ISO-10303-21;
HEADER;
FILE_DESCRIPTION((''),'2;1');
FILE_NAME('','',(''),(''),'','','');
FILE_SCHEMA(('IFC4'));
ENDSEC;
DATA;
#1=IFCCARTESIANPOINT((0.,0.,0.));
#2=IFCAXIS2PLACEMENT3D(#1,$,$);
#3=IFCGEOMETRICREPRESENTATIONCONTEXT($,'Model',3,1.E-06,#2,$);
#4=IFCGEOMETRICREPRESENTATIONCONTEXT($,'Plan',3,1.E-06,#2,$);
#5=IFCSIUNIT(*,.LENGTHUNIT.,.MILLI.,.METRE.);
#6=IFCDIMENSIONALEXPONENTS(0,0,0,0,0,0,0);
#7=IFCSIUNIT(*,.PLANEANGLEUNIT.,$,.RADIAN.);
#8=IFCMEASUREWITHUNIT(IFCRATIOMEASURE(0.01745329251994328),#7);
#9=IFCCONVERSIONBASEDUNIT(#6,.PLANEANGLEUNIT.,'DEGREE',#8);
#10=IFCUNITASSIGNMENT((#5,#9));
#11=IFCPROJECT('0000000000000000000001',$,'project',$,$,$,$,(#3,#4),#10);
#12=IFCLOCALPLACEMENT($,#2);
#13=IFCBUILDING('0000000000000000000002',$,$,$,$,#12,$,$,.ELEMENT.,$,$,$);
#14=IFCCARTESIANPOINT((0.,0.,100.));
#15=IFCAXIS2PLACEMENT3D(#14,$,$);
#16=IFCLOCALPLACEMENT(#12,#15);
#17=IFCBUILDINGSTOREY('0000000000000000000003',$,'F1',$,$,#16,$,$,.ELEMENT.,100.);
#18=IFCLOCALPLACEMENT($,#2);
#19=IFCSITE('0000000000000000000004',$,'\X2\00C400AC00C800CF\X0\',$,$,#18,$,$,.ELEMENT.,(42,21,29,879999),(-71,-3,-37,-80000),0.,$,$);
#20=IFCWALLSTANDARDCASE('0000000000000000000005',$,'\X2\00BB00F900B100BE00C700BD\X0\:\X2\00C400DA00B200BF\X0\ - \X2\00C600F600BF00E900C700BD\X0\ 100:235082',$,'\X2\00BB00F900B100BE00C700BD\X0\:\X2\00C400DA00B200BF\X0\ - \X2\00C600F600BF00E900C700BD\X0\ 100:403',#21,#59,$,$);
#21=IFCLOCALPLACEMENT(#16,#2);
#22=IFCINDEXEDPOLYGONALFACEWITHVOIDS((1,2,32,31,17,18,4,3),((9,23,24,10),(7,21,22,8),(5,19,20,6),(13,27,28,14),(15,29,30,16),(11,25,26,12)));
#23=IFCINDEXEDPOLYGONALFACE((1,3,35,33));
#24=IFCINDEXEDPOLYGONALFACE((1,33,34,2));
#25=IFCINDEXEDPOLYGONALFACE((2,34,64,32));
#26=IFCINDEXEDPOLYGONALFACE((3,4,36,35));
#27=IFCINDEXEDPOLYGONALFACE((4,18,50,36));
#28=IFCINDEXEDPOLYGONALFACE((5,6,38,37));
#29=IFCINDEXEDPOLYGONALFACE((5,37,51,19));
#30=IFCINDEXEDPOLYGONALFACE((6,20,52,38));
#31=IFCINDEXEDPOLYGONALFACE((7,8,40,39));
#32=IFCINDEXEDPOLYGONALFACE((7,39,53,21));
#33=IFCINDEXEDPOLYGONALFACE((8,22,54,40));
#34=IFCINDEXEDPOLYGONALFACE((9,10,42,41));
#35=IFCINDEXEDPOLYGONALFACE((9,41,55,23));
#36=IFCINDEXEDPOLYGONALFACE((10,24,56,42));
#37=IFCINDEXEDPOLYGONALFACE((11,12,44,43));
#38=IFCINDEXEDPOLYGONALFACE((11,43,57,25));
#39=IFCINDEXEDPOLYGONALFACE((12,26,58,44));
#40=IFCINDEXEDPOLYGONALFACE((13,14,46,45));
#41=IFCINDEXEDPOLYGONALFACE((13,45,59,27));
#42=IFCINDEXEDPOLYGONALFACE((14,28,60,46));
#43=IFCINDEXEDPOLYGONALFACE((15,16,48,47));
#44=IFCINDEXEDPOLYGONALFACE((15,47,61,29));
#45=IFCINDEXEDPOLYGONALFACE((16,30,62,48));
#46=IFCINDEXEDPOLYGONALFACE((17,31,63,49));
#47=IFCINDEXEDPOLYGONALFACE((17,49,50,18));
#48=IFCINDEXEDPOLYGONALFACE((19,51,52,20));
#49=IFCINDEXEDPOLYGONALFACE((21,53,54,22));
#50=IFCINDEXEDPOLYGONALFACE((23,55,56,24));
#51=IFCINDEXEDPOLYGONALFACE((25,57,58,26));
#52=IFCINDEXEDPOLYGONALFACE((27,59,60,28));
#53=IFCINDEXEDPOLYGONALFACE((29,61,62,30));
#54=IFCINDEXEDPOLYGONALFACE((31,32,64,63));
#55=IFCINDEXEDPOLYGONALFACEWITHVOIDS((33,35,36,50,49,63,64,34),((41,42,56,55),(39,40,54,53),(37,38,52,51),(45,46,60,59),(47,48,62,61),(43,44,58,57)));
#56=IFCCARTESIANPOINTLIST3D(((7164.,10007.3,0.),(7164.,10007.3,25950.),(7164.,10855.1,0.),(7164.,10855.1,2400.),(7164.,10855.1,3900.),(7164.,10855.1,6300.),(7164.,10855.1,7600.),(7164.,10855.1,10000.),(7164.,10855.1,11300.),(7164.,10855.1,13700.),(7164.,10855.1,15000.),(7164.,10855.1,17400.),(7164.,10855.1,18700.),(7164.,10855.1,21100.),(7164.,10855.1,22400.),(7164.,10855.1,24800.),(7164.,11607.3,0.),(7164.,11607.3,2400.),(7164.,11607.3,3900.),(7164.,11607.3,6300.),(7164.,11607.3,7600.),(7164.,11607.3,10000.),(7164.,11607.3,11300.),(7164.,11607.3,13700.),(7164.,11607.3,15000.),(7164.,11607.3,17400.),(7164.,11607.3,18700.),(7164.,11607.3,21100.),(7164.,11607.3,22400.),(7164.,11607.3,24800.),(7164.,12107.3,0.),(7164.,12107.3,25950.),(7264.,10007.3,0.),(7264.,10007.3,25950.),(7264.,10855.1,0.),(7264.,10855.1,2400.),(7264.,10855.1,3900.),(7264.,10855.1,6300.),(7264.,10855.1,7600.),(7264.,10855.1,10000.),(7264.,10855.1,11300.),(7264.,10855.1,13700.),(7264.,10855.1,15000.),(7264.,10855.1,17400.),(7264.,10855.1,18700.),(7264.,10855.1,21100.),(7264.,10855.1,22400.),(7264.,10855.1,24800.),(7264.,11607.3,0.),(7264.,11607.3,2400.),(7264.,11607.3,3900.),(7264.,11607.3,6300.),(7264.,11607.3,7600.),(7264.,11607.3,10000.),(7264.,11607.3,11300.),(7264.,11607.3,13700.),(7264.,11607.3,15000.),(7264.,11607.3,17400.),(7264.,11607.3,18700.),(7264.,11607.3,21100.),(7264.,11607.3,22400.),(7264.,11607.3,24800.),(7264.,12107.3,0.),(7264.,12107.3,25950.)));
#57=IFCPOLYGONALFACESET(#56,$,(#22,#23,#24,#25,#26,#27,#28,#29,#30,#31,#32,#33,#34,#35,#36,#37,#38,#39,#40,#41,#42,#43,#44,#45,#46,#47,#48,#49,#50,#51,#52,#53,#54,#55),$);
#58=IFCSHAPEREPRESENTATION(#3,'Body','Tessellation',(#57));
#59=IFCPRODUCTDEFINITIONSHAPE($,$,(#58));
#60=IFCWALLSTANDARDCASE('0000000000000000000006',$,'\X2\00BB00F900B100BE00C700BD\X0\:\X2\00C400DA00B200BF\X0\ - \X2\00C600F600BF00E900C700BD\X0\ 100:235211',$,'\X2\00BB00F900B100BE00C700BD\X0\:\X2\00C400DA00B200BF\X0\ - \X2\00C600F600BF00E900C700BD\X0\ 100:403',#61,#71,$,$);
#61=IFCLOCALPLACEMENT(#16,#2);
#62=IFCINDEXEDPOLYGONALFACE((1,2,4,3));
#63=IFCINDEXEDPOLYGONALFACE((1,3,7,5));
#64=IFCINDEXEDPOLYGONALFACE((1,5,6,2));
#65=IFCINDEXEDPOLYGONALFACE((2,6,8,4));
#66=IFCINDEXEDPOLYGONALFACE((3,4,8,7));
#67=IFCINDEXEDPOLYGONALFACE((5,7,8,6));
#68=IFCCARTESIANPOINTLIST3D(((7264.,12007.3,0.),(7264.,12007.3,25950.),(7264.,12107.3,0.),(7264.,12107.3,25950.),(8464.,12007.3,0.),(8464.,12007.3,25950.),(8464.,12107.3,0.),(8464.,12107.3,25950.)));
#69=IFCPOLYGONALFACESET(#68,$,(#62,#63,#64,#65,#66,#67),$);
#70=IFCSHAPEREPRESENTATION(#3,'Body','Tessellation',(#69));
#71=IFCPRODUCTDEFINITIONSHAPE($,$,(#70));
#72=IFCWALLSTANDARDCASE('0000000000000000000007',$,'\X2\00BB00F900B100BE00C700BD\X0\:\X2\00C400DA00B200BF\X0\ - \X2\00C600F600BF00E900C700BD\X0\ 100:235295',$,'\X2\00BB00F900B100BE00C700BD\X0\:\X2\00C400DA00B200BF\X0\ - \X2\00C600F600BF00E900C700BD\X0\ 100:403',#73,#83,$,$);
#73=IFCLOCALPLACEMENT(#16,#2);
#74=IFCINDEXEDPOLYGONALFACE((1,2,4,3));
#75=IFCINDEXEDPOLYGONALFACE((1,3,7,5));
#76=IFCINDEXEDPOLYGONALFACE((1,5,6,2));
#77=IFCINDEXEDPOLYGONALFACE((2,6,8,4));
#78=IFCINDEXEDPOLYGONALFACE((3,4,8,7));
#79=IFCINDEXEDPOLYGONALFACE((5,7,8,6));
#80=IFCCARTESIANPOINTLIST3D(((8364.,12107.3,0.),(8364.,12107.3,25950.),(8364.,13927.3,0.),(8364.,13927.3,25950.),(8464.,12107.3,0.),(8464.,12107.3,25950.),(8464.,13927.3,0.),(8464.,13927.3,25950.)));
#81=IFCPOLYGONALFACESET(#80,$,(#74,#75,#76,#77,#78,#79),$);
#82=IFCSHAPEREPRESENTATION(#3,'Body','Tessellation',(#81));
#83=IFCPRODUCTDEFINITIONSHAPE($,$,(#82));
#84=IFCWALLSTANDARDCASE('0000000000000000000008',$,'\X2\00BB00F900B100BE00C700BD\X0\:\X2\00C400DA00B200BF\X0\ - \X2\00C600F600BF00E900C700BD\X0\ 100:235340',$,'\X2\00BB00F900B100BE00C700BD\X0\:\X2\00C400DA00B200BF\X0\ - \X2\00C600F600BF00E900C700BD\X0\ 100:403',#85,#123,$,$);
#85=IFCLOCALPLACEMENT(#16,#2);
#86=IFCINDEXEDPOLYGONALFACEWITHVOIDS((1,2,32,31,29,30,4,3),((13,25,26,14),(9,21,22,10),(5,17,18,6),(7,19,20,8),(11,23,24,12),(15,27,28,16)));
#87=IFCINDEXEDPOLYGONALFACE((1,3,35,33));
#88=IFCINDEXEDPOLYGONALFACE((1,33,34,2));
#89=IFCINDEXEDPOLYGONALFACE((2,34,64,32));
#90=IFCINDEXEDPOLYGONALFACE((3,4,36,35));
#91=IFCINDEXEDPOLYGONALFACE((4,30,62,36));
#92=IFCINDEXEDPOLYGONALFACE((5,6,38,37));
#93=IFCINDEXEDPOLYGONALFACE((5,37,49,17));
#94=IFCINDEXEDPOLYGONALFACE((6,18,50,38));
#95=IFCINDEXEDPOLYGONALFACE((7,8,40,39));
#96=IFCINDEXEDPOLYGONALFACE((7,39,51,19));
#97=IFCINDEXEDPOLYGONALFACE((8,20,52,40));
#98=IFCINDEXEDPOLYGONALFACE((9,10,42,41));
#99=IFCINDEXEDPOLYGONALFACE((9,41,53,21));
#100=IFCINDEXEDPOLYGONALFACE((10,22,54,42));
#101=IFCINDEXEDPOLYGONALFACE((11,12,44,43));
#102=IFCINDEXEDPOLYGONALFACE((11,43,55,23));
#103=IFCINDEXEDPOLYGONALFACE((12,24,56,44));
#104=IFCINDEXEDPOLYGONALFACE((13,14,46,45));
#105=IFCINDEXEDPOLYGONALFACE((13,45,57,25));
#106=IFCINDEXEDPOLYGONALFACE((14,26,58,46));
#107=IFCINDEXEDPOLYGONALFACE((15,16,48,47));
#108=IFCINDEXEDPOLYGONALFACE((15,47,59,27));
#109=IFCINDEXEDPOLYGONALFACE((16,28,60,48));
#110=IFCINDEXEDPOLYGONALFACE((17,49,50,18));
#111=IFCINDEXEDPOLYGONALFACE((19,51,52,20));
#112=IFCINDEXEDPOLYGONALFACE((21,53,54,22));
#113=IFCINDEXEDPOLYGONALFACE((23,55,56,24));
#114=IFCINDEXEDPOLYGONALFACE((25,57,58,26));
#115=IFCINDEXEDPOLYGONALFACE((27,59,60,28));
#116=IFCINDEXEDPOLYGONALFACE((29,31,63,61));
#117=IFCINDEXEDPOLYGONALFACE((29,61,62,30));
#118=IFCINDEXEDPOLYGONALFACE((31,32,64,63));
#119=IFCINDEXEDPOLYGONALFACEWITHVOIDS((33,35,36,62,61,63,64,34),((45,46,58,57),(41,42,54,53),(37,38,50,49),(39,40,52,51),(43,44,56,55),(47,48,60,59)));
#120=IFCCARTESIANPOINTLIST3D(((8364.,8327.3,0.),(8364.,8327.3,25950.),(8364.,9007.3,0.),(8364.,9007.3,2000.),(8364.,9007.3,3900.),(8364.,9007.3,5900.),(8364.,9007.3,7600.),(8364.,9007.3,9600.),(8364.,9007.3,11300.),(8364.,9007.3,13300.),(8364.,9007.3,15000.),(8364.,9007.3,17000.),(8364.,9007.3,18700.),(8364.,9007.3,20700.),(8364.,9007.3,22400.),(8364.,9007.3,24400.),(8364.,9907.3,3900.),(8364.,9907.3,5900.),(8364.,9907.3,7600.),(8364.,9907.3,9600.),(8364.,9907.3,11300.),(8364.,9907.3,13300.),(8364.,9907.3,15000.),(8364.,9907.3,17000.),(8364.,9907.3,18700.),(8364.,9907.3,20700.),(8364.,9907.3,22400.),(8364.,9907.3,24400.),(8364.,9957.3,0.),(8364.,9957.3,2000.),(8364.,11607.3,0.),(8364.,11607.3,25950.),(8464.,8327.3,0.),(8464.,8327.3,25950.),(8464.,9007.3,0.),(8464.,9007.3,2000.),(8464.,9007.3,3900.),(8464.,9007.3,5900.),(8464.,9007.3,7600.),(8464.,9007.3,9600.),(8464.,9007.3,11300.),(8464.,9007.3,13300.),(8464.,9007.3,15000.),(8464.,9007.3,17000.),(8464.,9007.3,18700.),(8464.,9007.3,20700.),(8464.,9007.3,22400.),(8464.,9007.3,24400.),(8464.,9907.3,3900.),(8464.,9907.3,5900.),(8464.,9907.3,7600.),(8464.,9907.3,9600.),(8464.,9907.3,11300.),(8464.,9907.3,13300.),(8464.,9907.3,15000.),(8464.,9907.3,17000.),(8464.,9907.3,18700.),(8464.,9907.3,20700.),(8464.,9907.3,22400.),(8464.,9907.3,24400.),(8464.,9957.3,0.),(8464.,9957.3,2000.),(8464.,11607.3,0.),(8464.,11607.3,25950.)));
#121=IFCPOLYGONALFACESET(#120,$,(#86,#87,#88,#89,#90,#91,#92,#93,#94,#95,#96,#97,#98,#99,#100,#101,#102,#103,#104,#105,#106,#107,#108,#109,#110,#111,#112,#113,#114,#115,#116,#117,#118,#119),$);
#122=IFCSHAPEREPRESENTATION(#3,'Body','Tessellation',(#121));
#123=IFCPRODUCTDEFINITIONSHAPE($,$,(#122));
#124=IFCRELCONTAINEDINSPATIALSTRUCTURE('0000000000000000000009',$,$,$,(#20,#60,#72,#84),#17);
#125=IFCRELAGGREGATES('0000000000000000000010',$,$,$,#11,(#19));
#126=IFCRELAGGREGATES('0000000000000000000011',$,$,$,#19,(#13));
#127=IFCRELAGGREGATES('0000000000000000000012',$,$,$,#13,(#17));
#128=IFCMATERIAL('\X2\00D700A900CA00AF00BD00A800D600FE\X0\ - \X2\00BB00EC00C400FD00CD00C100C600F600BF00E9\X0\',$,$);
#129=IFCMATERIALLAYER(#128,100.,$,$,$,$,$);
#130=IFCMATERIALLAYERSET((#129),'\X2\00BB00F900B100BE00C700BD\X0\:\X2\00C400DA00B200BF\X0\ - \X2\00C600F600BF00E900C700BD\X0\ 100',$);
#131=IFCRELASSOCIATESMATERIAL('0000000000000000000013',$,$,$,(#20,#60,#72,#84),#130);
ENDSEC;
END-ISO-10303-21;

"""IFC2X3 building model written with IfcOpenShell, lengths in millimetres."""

from ifc_helpers import new_model, entity, si_unit, converted_unit, frame, frame_2d, origin, origin_2d_with_axis, place, context, project, spatial, polyline, rectangle, extrude, clip, bounded_halfspace, material, layer, layer_set, layer_usage, element, save


model = new_model("IFC2X3")

# Units and contexts
model_context = context("Model", 3, precision=1e-06, world=origin())
plan_context = context("Plan", 3, precision=1e-06, world=origin())
ifc_project = project(units=[si_unit("LENGTHUNIT", "METRE", prefix="MILLI"), converted_unit("PLANEANGLEUNIT", "DEGREE", entity("IfcRatioMeasure", 0.01745329251994328), si_unit("PLANEANGLEUNIT", "RADIAN"), dimensions=[0, 0, 0, 0, 0, 0, 0])], contexts=[model_context, plan_context])

# Site, building, storey
site_placement = place(None, origin())
site = spatial("IfcSite", under=ifc_project, at=site_placement, Name="Ä¬ÈÏ", CompositionType="ELEMENT", RefLatitude=(42, 21, 29, 879999), RefLongitude=(-71, -3, -37, -80000), RefElevation=0.0)
building_placement = place(None, origin())
building = spatial("IfcBuilding", under=site, at=building_placement, CompositionType="ELEMENT")
storey_placement = place(building_placement, frame((0.0, 0.0, 100.0)))
storey = spatial("IfcBuildingStorey", under=building, at=storey_placement, Name="F1", CompositionType="ELEMENT", Elevation=100.0)

# Shared definitions
ifc_material_1 = material(Name="×©Ê¯½¨Öþ - »ìÄýÍÁÆö¿é")
ifc_layer_1 = layer(ifc_material_1, 100.0)
ifc_layer_set_1 = layer_set([ifc_layer_1], Name="»ù±¾Ç½:ÄÚ²¿ - Æö¿éÇ½ 100")

# Wall, openings
ifc_layer_usage_1 = layer_usage(ifc_layer_set_1, "AXIS2", "NEGATIVE", 50.0)
wall_1_placement = place(storey_placement, frame((7214.0, 12107.3, 0.0), z_axis=(0.0, 0.0, 1.0), x_axis=(0.0, -1.0, 0.0)))
wall_1 = element("IfcWallStandardCase", 1, at=wall_1_placement, inside=storey, material=ifc_layer_usage_1, Name="»ù±¾Ç½:ÄÚ²¿ - Æö¿éÇ½ 100:235082", ObjectType="»ù±¾Ç½:ÄÚ²¿ - Æö¿éÇ½ 100:403", context=model_context, shape_type="Clipping", body=[
    clip(extrude(rectangle(XDim=2100.0, YDim=100.0, at=frame_2d((1050.0, 0.0), x_axis=(-1.0, 0.0))), origin(), (0.0, 0.0, 1.0), 25950.0), bounded_halfspace(frame((0.0, -50.0, 25950.0), z_axis=(0.0, 0.0, -1.0), x_axis=(0.0, 1.0, 0.0)), True, frame((0.0, -50.0, 25950.0)), polyline([(0.0, 0.0), (2100.0, 0.0), (2100.0, 100.0), (500.0, 100.0), (400.0, 100.0), (100.0, 100.0), (0.0, 100.0), (0.0, 0.0)]))),
])
opening_1_placement = place(wall_1_placement, origin())
element("IfcOpeningElement", 2, at=opening_1_placement, cuts=wall_1, ObjectType="Opening", context=model_context, shape_type="SweptSolid", body=[
    extrude(rectangle(XDim=2400.0, YDim=752.2, at=origin_2d_with_axis()), frame((876.1, -50.0, 1200.0), z_axis=(0.0, 1.0, 0.0), x_axis=(0.0, 0.0, -1.0)), (0.0, 0.0, 1.0), 100.0),
])
opening_2_placement = place(wall_1_placement, origin())
element("IfcOpeningElement", 3, at=opening_2_placement, cuts=wall_1, ObjectType="Opening", context=model_context, shape_type="SweptSolid", body=[
    extrude(rectangle(XDim=2400.0, YDim=752.2, at=origin_2d_with_axis()), frame((876.1, -50.0, 5100.0), z_axis=(0.0, 1.0, 0.0), x_axis=(0.0, 0.0, -1.0)), (0.0, 0.0, 1.0), 100.0),
])
opening_3_placement = place(wall_1_placement, origin())
element("IfcOpeningElement", 4, at=opening_3_placement, cuts=wall_1, ObjectType="Opening", context=model_context, shape_type="SweptSolid", body=[
    extrude(rectangle(XDim=2400.0, YDim=752.2, at=origin_2d_with_axis()), frame((876.1, -50.0, 8800.0), z_axis=(0.0, 1.0, 0.0), x_axis=(0.0, 0.0, -1.0)), (0.0, 0.0, 1.0), 100.0),
])
opening_4_placement = place(wall_1_placement, origin())
element("IfcOpeningElement", 5, at=opening_4_placement, cuts=wall_1, ObjectType="Opening", context=model_context, shape_type="SweptSolid", body=[
    extrude(rectangle(XDim=2400.0, YDim=752.2, at=origin_2d_with_axis()), frame((876.1, -50.0, 12500.0), z_axis=(0.0, 1.0, 0.0), x_axis=(0.0, 0.0, -1.0)), (0.0, 0.0, 1.0), 100.0),
])
opening_5_placement = place(wall_1_placement, origin())
element("IfcOpeningElement", 6, at=opening_5_placement, cuts=wall_1, ObjectType="Opening", context=model_context, shape_type="SweptSolid", body=[
    extrude(rectangle(XDim=2400.0, YDim=752.2, at=origin_2d_with_axis()), frame((876.1, -50.0, 16200.0), z_axis=(0.0, 1.0, 0.0), x_axis=(0.0, 0.0, -1.0)), (0.0, 0.0, 1.0), 100.0),
])
opening_6_placement = place(wall_1_placement, origin())
element("IfcOpeningElement", 7, at=opening_6_placement, cuts=wall_1, ObjectType="Opening", context=model_context, shape_type="SweptSolid", body=[
    extrude(rectangle(XDim=2400.0, YDim=752.2, at=origin_2d_with_axis()), frame((876.1, -50.0, 19900.0), z_axis=(0.0, 1.0, 0.0), x_axis=(0.0, 0.0, -1.0)), (0.0, 0.0, 1.0), 100.0),
])
opening_7_placement = place(wall_1_placement, origin())
element("IfcOpeningElement", 8, at=opening_7_placement, cuts=wall_1, ObjectType="Opening", context=model_context, shape_type="SweptSolid", body=[
    extrude(rectangle(XDim=2400.0, YDim=752.2, at=origin_2d_with_axis()), frame((876.1, -50.0, 23600.0), z_axis=(0.0, 1.0, 0.0), x_axis=(0.0, 0.0, -1.0)), (0.0, 0.0, 1.0), 100.0),
])

# Walls
ifc_layer_usage_2 = layer_usage(ifc_layer_set_1, "AXIS2", "NEGATIVE", 50.0)
wall_2_placement = place(storey_placement, frame((7264.0, 12057.3, 0.0)))
element("IfcWallStandardCase", 9, at=wall_2_placement, inside=storey, material=ifc_layer_usage_2, Name="»ù±¾Ç½:ÄÚ²¿ - Æö¿éÇ½ 100:235211", ObjectType="»ù±¾Ç½:ÄÚ²¿ - Æö¿éÇ½ 100:403", context=model_context, shape_type="Clipping", body=[
    clip(extrude(rectangle(XDim=1200.0, YDim=100.0, at=frame_2d((600.0, 0.0), x_axis=(-1.0, 0.0))), origin(), (0.0, 0.0, 1.0), 25950.0), bounded_halfspace(frame((0.0, -50.0, 25950.0), z_axis=(0.0, 0.0, -1.0), x_axis=(1.0, 0.0, 0.0)), True, frame((0.0, -50.0, 25950.0)), polyline([(0.0, 0.0), (1200.0, 0.0), (1200.0, 100.0), (1100.0, 100.0), (0.0, 100.0), (0.0, 0.0)]))),
])
ifc_layer_usage_3 = layer_usage(ifc_layer_set_1, "AXIS2", "NEGATIVE", 50.0)
wall_3_placement = place(storey_placement, frame((8414.0, 13927.3, 0.0), z_axis=(0.0, 0.0, 1.0), x_axis=(0.0, -1.0, 0.0)))
element("IfcWallStandardCase", 10, at=wall_3_placement, inside=storey, material=ifc_layer_usage_3, Name="»ù±¾Ç½:ÄÚ²¿ - Æö¿éÇ½ 100:235295", ObjectType="»ù±¾Ç½:ÄÚ²¿ - Æö¿éÇ½ 100:403", context=model_context, shape_type="Clipping", body=[
    clip(extrude(rectangle(XDim=1820.0, YDim=100.0, at=frame_2d((910.0, 0.0), x_axis=(-1.0, 0.0))), origin(), (0.0, 0.0, 1.0), 25950.0), bounded_halfspace(frame((0.0, -50.0, 25950.0), z_axis=(0.0, 0.0, -1.0), x_axis=(0.0, 1.0, 0.0)), True, frame((0.0, -50.0, 25950.0)), polyline([(0.0, 0.0), (1820.0, 0.0), (1820.0, 100.0), (0.0, 100.0), (0.0, 0.0)]))),
])

# Wall, openings
ifc_layer_usage_4 = layer_usage(ifc_layer_set_1, "AXIS2", "NEGATIVE", 50.0)
wall_4_placement = place(storey_placement, frame((8414.0, 11607.3, 0.0), z_axis=(0.0, 0.0, 1.0), x_axis=(0.0, -1.0, 0.0)))
wall_4 = element("IfcWallStandardCase", 11, at=wall_4_placement, inside=storey, material=ifc_layer_usage_4, Name="»ù±¾Ç½:ÄÚ²¿ - Æö¿éÇ½ 100:235340", ObjectType="»ù±¾Ç½:ÄÚ²¿ - Æö¿éÇ½ 100:403", context=model_context, shape_type="Clipping", body=[
    clip(extrude(rectangle(XDim=3280.0, YDim=100.0, at=frame_2d((1640.0, 0.0), x_axis=(-1.0, 0.0))), origin(), (0.0, 0.0, 1.0), 25950.0), bounded_halfspace(frame((0.0, -50.0, 25950.0), z_axis=(0.0, 0.0, -1.0), x_axis=(0.0, 1.0, 0.0)), True, frame((0.0, -50.0, 25950.0)), polyline([(0.0, 0.0), (1600.0, 0.0), (1700.0, 0.0), (3180.0, 0.0), (3280.0, 0.0), (3280.0, 100.0), (2880.0, 100.0), (0.0, 100.0), (0.0, 0.0)]))),
])
opening_8_placement = place(wall_4_placement, origin())
element("IfcOpeningElement", 12, at=opening_8_placement, cuts=wall_4, ObjectType="Opening", context=model_context, shape_type="SweptSolid", body=[
    extrude(rectangle(XDim=2000.0, YDim=950.0, at=origin_2d_with_axis()), frame((2125.0, -50.0, 1000.0), z_axis=(0.0, 1.0, 0.0), x_axis=(0.0, 0.0, -1.0)), (0.0, 0.0, 1.0), 100.0),
])
opening_9_placement = place(wall_4_placement, origin())
element("IfcOpeningElement", 13, at=opening_9_placement, cuts=wall_4, ObjectType="Opening", context=model_context, shape_type="SweptSolid", body=[
    extrude(rectangle(XDim=2000.0, YDim=900.0, at=origin_2d_with_axis()), frame((2150.0, -50.0, 4900.0), z_axis=(0.0, 1.0, 0.0), x_axis=(0.0, 0.0, -1.0)), (0.0, 0.0, 1.0), 100.0),
])
opening_10_placement = place(wall_4_placement, origin())
element("IfcOpeningElement", 14, at=opening_10_placement, cuts=wall_4, ObjectType="Opening", context=model_context, shape_type="SweptSolid", body=[
    extrude(rectangle(XDim=2000.0, YDim=900.0, at=origin_2d_with_axis()), frame((2150.0, -50.0, 8600.0), z_axis=(0.0, 1.0, 0.0), x_axis=(0.0, 0.0, -1.0)), (0.0, 0.0, 1.0), 100.0),
])
opening_11_placement = place(wall_4_placement, origin())
element("IfcOpeningElement", 15, at=opening_11_placement, cuts=wall_4, ObjectType="Opening", context=model_context, shape_type="SweptSolid", body=[
    extrude(rectangle(XDim=2000.0, YDim=900.0, at=origin_2d_with_axis()), frame((2150.0, -50.0, 12300.0), z_axis=(0.0, 1.0, 0.0), x_axis=(0.0, 0.0, -1.0)), (0.0, 0.0, 1.0), 100.0),
])
opening_12_placement = place(wall_4_placement, origin())
element("IfcOpeningElement", 16, at=opening_12_placement, cuts=wall_4, ObjectType="Opening", context=model_context, shape_type="SweptSolid", body=[
    extrude(rectangle(XDim=2000.0, YDim=900.0, at=origin_2d_with_axis()), frame((2150.0, -50.0, 16000.0), z_axis=(0.0, 1.0, 0.0), x_axis=(0.0, 0.0, -1.0)), (0.0, 0.0, 1.0), 100.0),
])
opening_13_placement = place(wall_4_placement, origin())
element("IfcOpeningElement", 17, at=opening_13_placement, cuts=wall_4, ObjectType="Opening", context=model_context, shape_type="SweptSolid", body=[
    extrude(rectangle(XDim=2000.0, YDim=900.0, at=origin_2d_with_axis()), frame((2150.0, -50.0, 19700.0), z_axis=(0.0, 1.0, 0.0), x_axis=(0.0, 0.0, -1.0)), (0.0, 0.0, 1.0), 100.0),
])
opening_14_placement = place(wall_4_placement, origin())
element("IfcOpeningElement", 18, at=opening_14_placement, cuts=wall_4, ObjectType="Opening", context=model_context, shape_type="SweptSolid", body=[
    extrude(rectangle(XDim=2000.0, YDim=900.0, at=origin_2d_with_axis()), frame((2150.0, -50.0, 23400.0), z_axis=(0.0, 1.0, 0.0), x_axis=(0.0, 0.0, -1.0)), (0.0, 0.0, 1.0), 100.0),
])

save(model, "model.ifc")
